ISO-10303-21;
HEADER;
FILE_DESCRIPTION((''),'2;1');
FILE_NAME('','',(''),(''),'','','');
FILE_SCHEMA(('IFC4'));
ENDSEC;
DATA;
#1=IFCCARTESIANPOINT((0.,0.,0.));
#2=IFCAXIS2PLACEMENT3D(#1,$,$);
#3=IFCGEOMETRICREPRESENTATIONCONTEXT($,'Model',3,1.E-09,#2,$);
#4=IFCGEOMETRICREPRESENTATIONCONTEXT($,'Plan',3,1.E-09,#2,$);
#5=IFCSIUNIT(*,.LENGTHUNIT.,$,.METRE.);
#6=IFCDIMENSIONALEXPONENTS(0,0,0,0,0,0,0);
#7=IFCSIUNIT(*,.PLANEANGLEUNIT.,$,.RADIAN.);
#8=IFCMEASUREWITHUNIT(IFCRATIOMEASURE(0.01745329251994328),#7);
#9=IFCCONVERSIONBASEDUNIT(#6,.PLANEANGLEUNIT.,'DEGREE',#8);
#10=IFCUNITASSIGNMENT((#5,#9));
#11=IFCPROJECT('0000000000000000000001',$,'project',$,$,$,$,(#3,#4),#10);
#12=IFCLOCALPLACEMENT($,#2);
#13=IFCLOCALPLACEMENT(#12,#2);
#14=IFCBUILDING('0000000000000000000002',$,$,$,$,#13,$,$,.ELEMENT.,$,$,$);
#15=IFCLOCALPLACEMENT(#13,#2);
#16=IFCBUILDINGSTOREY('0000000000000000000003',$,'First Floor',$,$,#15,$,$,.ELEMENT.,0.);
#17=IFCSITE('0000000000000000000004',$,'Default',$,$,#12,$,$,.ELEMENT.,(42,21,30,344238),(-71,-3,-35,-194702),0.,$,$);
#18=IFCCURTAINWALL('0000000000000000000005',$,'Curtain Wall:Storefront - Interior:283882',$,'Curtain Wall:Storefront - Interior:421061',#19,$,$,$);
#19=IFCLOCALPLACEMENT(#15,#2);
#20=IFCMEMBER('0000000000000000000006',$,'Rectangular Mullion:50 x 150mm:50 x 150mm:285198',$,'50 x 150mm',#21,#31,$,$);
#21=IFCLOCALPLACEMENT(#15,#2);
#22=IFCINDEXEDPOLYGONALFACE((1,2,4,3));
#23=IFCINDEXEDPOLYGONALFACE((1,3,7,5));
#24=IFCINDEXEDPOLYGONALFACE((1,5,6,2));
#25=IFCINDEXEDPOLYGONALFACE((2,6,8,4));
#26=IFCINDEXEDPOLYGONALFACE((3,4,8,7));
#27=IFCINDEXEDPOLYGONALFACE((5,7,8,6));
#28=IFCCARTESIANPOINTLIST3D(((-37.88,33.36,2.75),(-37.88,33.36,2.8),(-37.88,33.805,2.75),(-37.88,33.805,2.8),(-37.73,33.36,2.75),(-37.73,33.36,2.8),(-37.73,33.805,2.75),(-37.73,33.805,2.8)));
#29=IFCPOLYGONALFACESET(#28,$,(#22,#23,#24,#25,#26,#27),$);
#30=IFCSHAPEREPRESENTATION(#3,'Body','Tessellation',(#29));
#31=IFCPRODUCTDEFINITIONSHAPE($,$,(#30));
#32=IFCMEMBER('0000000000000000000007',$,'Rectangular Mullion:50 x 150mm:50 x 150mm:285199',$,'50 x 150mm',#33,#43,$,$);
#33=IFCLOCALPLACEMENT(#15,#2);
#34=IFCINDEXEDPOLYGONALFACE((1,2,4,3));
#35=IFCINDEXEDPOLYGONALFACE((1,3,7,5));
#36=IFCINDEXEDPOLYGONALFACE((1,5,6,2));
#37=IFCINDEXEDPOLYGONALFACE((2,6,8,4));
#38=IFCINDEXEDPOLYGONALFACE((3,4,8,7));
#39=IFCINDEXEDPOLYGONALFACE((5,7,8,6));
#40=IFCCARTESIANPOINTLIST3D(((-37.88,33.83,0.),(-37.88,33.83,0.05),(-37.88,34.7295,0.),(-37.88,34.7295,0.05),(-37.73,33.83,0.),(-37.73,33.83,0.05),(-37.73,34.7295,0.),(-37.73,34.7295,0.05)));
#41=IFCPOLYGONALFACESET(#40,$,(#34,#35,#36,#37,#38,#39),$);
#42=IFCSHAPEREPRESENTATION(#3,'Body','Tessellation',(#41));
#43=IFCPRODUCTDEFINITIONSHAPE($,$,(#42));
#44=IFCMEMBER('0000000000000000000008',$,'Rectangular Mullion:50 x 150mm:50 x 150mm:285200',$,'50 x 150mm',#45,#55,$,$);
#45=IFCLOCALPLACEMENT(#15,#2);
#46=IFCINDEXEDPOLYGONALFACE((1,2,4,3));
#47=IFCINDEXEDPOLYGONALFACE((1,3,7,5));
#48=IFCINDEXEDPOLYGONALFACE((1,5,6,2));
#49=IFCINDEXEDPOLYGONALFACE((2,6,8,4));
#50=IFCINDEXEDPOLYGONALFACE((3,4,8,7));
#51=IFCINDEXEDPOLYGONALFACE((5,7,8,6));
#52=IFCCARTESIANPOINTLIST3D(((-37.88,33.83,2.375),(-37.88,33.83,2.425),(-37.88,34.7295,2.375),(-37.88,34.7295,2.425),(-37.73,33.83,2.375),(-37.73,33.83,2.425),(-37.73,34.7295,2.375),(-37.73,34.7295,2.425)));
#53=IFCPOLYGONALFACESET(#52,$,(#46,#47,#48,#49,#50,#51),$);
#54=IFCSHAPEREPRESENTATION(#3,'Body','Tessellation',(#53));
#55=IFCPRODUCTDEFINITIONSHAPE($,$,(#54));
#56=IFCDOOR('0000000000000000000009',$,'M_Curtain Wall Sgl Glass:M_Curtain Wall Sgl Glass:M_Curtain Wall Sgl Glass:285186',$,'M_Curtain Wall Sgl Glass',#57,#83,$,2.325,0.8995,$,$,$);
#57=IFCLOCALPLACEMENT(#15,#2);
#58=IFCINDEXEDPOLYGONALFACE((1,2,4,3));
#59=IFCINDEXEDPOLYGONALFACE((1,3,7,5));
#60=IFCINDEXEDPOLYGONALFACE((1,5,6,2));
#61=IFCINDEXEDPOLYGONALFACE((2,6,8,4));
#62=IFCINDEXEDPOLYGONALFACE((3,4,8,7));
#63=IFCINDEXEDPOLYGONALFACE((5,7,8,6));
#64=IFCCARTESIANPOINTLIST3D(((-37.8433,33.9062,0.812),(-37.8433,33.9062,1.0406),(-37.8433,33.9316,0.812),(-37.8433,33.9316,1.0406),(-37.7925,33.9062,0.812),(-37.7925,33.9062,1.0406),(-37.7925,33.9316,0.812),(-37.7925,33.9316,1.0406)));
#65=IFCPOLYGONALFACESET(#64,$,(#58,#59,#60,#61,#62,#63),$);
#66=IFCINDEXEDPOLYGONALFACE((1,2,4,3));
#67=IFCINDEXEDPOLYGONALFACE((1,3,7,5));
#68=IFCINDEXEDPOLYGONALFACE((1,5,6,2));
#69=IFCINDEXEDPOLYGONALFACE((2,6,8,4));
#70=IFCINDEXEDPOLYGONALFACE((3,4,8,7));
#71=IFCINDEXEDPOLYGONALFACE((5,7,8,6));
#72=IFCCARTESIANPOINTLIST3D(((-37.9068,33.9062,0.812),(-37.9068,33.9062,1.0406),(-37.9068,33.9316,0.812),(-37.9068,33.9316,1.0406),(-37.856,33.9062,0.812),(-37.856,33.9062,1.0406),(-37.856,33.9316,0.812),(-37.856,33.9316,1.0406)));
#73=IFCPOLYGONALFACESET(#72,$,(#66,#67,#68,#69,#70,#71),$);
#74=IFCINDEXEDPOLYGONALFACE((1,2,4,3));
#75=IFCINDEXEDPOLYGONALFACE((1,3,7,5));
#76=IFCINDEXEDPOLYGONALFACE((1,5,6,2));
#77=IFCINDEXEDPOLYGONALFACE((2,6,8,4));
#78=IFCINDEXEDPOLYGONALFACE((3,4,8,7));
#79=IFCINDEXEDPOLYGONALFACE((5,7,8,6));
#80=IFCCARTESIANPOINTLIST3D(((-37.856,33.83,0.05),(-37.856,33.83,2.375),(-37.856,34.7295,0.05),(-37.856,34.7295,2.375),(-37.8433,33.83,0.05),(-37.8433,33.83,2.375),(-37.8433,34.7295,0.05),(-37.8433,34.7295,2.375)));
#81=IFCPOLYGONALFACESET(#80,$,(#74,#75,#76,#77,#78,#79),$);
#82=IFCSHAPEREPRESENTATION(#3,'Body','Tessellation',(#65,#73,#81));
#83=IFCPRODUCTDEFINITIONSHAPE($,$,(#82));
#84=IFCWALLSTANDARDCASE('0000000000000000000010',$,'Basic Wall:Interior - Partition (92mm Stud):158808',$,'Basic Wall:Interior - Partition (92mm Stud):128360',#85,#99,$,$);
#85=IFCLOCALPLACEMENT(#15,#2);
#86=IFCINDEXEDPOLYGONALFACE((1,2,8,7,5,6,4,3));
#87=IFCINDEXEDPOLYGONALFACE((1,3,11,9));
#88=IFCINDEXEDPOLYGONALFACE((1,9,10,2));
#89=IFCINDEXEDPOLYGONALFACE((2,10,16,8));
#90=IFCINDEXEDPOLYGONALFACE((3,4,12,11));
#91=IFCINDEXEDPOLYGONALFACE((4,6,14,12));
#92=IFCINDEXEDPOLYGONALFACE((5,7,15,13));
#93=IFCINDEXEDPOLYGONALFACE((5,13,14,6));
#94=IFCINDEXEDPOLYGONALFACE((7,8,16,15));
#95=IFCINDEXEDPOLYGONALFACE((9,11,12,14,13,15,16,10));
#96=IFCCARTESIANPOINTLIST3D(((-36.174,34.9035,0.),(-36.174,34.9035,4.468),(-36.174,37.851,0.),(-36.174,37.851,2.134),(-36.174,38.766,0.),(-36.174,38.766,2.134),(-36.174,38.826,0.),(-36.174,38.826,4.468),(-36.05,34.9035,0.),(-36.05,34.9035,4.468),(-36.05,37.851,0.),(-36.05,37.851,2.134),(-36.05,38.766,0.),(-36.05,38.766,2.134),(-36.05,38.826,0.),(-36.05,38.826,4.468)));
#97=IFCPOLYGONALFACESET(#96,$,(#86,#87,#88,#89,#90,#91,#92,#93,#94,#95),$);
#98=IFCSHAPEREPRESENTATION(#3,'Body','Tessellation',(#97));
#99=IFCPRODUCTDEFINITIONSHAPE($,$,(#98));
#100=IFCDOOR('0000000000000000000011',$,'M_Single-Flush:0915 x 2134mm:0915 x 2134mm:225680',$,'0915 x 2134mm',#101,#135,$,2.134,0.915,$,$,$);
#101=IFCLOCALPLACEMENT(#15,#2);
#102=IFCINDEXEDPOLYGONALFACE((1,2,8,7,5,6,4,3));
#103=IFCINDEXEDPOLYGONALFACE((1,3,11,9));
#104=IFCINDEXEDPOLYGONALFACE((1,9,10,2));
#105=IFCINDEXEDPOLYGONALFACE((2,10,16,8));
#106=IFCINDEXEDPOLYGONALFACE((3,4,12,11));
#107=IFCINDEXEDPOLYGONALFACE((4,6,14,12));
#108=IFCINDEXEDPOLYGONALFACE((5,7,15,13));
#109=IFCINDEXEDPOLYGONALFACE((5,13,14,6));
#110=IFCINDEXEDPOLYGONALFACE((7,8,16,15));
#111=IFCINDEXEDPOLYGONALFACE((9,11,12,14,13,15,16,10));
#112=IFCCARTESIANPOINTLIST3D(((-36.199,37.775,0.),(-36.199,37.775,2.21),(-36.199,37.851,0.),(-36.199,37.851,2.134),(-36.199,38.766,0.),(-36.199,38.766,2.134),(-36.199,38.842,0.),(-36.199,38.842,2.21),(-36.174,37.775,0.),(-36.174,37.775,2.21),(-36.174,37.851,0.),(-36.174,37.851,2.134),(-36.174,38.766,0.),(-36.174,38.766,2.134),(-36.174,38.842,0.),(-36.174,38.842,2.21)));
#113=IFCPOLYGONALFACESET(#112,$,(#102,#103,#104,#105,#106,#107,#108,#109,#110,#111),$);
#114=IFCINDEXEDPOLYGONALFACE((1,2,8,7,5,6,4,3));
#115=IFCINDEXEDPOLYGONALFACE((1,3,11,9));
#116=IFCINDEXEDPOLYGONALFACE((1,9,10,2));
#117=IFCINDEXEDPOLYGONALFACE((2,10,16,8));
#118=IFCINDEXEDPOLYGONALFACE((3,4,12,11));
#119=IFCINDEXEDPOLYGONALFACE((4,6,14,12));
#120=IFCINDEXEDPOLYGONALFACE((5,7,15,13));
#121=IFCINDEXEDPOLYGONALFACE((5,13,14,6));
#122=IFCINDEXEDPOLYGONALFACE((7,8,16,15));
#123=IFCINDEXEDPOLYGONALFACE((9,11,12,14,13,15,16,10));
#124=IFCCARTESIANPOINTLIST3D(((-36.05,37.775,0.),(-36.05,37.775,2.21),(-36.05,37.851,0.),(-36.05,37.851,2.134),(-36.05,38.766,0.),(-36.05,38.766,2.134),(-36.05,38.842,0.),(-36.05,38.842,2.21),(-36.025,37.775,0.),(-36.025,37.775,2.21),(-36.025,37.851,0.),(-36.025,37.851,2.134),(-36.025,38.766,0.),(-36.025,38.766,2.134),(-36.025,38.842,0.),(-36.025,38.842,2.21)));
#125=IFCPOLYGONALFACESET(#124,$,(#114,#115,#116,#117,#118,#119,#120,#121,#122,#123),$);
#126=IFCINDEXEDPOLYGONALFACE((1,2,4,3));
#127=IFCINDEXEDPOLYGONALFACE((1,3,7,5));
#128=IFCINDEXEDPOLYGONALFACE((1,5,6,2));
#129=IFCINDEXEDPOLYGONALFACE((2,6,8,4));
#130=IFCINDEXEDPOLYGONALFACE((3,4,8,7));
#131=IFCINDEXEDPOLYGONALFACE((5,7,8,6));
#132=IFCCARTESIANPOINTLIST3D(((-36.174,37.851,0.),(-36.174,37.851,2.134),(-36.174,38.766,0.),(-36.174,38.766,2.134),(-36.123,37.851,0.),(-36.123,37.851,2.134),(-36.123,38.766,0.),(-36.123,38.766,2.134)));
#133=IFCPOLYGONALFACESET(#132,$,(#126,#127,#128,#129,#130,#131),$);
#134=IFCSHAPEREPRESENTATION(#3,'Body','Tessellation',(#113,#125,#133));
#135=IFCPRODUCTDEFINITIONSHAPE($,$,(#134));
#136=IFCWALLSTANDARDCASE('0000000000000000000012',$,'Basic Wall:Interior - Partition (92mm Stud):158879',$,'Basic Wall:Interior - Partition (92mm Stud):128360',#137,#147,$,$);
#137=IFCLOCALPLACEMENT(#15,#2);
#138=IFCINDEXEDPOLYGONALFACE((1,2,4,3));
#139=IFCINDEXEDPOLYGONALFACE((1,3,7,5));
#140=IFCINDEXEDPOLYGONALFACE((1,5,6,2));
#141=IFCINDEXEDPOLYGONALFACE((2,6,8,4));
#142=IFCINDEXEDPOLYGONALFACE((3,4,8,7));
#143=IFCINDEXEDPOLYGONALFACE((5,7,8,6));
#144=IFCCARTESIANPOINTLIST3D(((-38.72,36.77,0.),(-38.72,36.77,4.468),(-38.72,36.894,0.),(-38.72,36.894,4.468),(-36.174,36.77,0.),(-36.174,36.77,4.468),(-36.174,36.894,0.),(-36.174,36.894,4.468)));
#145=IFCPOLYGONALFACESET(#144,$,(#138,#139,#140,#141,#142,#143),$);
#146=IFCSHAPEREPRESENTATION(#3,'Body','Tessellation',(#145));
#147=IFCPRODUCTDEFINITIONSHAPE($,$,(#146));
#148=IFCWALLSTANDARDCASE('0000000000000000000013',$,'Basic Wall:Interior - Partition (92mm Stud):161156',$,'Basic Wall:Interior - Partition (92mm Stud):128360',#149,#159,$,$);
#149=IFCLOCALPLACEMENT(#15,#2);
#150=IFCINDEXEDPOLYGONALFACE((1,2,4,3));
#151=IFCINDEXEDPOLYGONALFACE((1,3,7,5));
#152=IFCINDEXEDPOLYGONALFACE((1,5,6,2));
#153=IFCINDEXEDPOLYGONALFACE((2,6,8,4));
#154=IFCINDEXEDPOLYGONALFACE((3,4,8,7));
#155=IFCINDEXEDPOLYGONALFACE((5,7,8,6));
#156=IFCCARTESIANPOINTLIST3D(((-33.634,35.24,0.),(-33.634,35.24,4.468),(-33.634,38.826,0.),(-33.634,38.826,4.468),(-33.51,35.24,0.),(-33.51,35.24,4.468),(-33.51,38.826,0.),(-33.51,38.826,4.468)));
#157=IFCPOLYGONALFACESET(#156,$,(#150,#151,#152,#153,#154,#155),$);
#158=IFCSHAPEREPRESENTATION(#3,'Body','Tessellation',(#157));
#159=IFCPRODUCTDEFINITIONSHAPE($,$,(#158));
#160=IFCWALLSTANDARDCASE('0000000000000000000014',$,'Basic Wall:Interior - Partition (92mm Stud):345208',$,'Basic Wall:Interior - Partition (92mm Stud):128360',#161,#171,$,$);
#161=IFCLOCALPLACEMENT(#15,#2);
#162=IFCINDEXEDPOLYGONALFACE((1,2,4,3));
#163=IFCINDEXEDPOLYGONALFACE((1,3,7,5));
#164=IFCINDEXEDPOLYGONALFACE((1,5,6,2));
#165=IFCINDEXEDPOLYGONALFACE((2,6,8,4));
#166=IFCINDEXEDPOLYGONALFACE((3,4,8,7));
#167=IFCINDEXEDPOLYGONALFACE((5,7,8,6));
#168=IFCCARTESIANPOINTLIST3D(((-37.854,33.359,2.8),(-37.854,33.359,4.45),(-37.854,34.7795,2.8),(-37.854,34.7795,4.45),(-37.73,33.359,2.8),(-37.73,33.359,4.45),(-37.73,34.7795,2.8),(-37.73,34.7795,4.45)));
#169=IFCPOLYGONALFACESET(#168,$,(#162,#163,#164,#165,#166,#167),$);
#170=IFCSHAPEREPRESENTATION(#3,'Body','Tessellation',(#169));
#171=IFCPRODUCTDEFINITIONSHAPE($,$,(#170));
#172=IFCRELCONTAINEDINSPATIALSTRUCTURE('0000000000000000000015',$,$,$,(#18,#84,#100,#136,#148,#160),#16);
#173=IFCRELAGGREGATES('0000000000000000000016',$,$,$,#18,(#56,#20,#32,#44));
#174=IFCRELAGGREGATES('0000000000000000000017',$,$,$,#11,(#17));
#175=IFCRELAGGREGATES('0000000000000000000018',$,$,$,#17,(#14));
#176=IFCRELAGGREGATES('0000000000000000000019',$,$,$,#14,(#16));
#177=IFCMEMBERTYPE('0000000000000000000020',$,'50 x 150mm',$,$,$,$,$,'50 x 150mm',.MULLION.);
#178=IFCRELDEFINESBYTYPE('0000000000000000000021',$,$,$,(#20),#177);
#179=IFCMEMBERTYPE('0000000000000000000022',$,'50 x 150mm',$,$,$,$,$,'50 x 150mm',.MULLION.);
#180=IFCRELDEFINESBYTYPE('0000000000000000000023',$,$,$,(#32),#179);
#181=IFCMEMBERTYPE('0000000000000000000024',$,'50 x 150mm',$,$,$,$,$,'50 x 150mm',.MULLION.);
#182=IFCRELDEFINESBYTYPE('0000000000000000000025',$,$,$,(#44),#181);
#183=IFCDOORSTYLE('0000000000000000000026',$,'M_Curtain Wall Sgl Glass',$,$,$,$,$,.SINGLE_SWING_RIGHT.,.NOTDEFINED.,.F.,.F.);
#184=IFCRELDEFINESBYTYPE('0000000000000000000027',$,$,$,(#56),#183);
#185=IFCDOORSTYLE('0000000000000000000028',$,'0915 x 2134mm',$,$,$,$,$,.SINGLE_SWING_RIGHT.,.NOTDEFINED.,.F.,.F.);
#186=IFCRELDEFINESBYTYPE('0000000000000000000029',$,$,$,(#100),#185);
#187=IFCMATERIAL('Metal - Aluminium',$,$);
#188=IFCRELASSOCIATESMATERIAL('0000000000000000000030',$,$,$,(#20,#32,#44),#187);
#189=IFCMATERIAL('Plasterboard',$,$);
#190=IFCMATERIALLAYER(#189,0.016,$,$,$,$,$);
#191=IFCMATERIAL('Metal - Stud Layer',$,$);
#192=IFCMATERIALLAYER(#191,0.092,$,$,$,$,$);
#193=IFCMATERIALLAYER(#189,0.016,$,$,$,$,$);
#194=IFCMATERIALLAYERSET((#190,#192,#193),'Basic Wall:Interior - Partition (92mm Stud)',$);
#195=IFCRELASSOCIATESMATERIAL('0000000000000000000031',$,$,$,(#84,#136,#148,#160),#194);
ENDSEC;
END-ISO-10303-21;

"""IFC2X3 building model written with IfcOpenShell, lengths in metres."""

from ifc_helpers import new_model, entity, si_unit, converted_unit, frame, frame_2d, origin, origin_2d_with_axis, place, context, project, spatial, polyline, rectangle, outline, extrude, source, transform, mapped, material, layer, layer_set, layer_usage, type_object, type_shapes, element, fill, aggregate, save


model = new_model("IFC2X3")

# Units and contexts
model_context = context("Model", 3, precision=1e-09, world=origin())
plan_context = context("Plan", 3, precision=1e-09, world=origin())
ifc_project = project(units=[si_unit("LENGTHUNIT", "METRE"), converted_unit("PLANEANGLEUNIT", "DEGREE", entity("IfcRatioMeasure", 0.01745329251994328), si_unit("PLANEANGLEUNIT", "RADIAN"), dimensions=[0, 0, 0, 0, 0, 0, 0])], contexts=[model_context, plan_context])

# Site, building, storey
site_placement = place(None, origin())
site = spatial("IfcSite", under=ifc_project, at=site_placement, Name="Default", CompositionType="ELEMENT", RefLatitude=(42, 21, 30, 344238), RefLongitude=(-71, -3, -35, -194702), RefElevation=0.0)
building_placement = place(site_placement, origin())
building = spatial("IfcBuilding", under=site, at=building_placement, CompositionType="ELEMENT")
storey_placement = place(building_placement, origin())
storey = spatial("IfcBuildingStorey", under=building, at=storey_placement, Name="First Floor", CompositionType="ELEMENT", Elevation=0.0)

# Shared definitions
ifc_material_1 = material(Name="Metal - Aluminium")

# Curtain wall
curtain_wall_1_placement = place(storey_placement, origin())
curtain_wall_1 = element("IfcCurtainWall", 1, at=curtain_wall_1_placement, inside=storey, Name="Curtain Wall:Storefront - Interior:283882", ObjectType="Curtain Wall:Storefront - Interior:421061")

# Members
member_type_1 = type_object("IfcMemberType", Name="50 x 150mm", ElementType="50 x 150mm", PredefinedType="MULLION")
shared_shape_1 = source(origin(), model_context, "Body", "SweptSolid", [
    extrude(rectangle(XDim=0.05, YDim=0.15, at=origin_2d_with_axis()), frame((-0.025, 0.0, -0.445), z_axis=(0.0, 0.0, 1.0), x_axis=(-1.0, 0.0, 0.0)), (0.0, 0.0, 1.0), 0.445),
])
type_shapes(member_type_1, [shared_shape_1])
member_1_placement = place(storey_placement, frame((-37.805, 33.805, 2.8), z_axis=(0.0, 1.0, 0.0), x_axis=(0.0, 0.0, 1.0)))
member_1 = element("IfcMember", 2, at=member_1_placement, type_object=member_type_1, material=ifc_material_1, Name="Rectangular Mullion:50 x 150mm:50 x 150mm:285198", ObjectType="50 x 150mm", context=model_context, shape_type="MappedRepresentation", body=[
    mapped(shared_shape_1, transform((0.0, 0.0, 0.0), scale=1.0)),
])
member_type_2 = type_object("IfcMemberType", Name="50 x 150mm", ElementType="50 x 150mm", PredefinedType="MULLION")
shared_shape_2 = source(origin(), model_context, "Body", "SweptSolid", [
    extrude(rectangle(XDim=0.05, YDim=0.15, at=origin_2d_with_axis()), frame((-0.025, 0.0, -0.8995), z_axis=(0.0, 0.0, 1.0), x_axis=(-1.0, 0.0, 0.0)), (0.0, 0.0, 1.0), 0.8995),
])
type_shapes(member_type_2, [shared_shape_2])
member_2_placement = place(storey_placement, frame((-37.805, 33.83, 0.0), z_axis=(0.0, -1.0, 0.0), x_axis=(0.0, 0.0, -1.0)))
member_2 = element("IfcMember", 3, at=member_2_placement, type_object=member_type_2, material=ifc_material_1, Name="Rectangular Mullion:50 x 150mm:50 x 150mm:285199", ObjectType="50 x 150mm", context=model_context, shape_type="MappedRepresentation", body=[
    mapped(shared_shape_2, transform((0.0, 0.0, 0.0), scale=1.0)),
])
member_type_3 = type_object("IfcMemberType", Name="50 x 150mm", ElementType="50 x 150mm", PredefinedType="MULLION")
shared_shape_3 = source(origin(), model_context, "Body", "SweptSolid", [
    extrude(rectangle(XDim=0.05, YDim=0.15, at=origin_2d_with_axis()), frame((0.0, 0.0, -0.8995), z_axis=(0.0, 0.0, 1.0), x_axis=(-1.0, 0.0, 0.0)), (0.0, 0.0, 1.0), 0.8995),
])
type_shapes(member_type_3, [shared_shape_3])
member_3_placement = place(storey_placement, frame((-37.805, 34.7295, 2.4), z_axis=(0.0, 1.0, 0.0), x_axis=(0.0, 0.0, 1.0)))
member_3 = element("IfcMember", 4, at=member_3_placement, type_object=member_type_3, material=ifc_material_1, Name="Rectangular Mullion:50 x 150mm:50 x 150mm:285200", ObjectType="50 x 150mm", context=model_context, shape_type="MappedRepresentation", body=[
    mapped(shared_shape_3, transform((0.0, 0.0, 0.0), scale=1.0)),
])

# Door
door_style_1 = type_object("IfcDoorStyle", Name="M_Curtain Wall Sgl Glass", ConstructionType="NOTDEFINED", OperationType="SINGLE_SWING_RIGHT", ParameterTakesPrecedence=False, Sizeable=False)
shared_shape_4 = source(origin(), model_context, "Body", "SweptSolid", [
    extrude(rectangle(XDim=0.0508, YDim=0.0254, at=origin_2d_with_axis()), frame((-0.3609, 0.0129, 0.762), z_axis=(0.0, 0.0, 1.0), x_axis=(0.0, 1.0, 0.0)), (0.0, 0.0, 1.0), 0.2286),
    extrude(rectangle(XDim=0.0508, YDim=0.0254, at=origin_2d_with_axis()), frame((-0.3609, 0.0764, 0.762), z_axis=(0.0, 0.0, 1.0), x_axis=(0.0, -1.0, 0.0)), (0.0, 0.0, 1.0), 0.2286),
    extrude(rectangle(XDim=0.8995, YDim=0.0127, at=origin_2d_with_axis()), frame((0.0, 0.0447, 0.0), z_axis=(0.0, 0.0, 1.0), x_axis=(-1.0, 0.0, 0.0)), (0.0, 0.0, 1.0), 2.325),
])
type_shapes(door_style_1, [shared_shape_4])
door_1_placement = place(storey_placement, frame((-37.805, 34.2798, 0.05), z_axis=(0.0, 0.0, 1.0), x_axis=(0.0, 1.0, 0.0)))
door_1 = element("IfcDoor", 5, at=door_1_placement, type_object=door_style_1, Name="M_Curtain Wall Sgl Glass:M_Curtain Wall Sgl Glass:M_Curtain Wall Sgl Glass:285186", ObjectType="M_Curtain Wall Sgl Glass", OverallHeight=2.325, OverallWidth=0.8995, context=model_context, shape_type="MappedRepresentation", body=[
    mapped(shared_shape_4, transform((0.0, 0.0, 0.0), scale=1.0)),
])
aggregate(curtain_wall_1, [door_1, member_1, member_2, member_3])

# Wall, opening, door
ifc_material_2 = material(Name="Plasterboard")
ifc_layer_1 = layer(ifc_material_2, 0.016)
ifc_material_3 = material(Name="Metal - Stud Layer")
ifc_layer_2 = layer(ifc_material_3, 0.092)
ifc_layer_3 = layer(ifc_material_2, 0.016)
ifc_layer_set_1 = layer_set([ifc_layer_1, ifc_layer_2, ifc_layer_3], Name="Basic Wall:Interior - Partition (92mm Stud)")
ifc_layer_usage_1 = layer_usage(ifc_layer_set_1, "AXIS2", "NEGATIVE", 0.062)
wall_1_placement = place(storey_placement, frame((-36.112, 38.826, 0.0), z_axis=(0.0, 0.0, 1.0), x_axis=(0.0, -1.0, 0.0)))
wall_1 = element("IfcWallStandardCase", 6, at=wall_1_placement, inside=storey, material=ifc_layer_usage_1, Name="Basic Wall:Interior - Partition (92mm Stud):158808", ObjectType="Basic Wall:Interior - Partition (92mm Stud):128360", context=model_context, shape_type="SweptSolid", body=[
    extrude(rectangle(XDim=3.9225, YDim=0.124, at=frame_2d((1.9612, 0.0), x_axis=(-1.0, 0.0))), origin(), (0.0, 0.0, 1.0), 4.468),
])
opening_placement = place(wall_1_placement, frame((0.975, 0.062, 0.0)))
opening = element("IfcOpeningElement", 7, at=opening_placement, cuts=wall_1, ObjectType="Opening", context=model_context, shape_type="SweptSolid", body=[
    extrude(rectangle(XDim=0.915, YDim=2.134, at=frame_2d((1.067, 0.4575), x_axis=(0.0, 1.0))), frame((0.0, 0.0, 0.0), z_axis=(0.0, -1.0, 0.0), x_axis=(0.0, 0.0, 1.0)), (0.0, 0.0, 1.0), 0.124),
])
door_style_2 = type_object("IfcDoorStyle", Name="0915 x 2134mm", ConstructionType="NOTDEFINED", OperationType="SINGLE_SWING_RIGHT", ParameterTakesPrecedence=False, Sizeable=False)
shared_shape_5 = source(origin(), model_context, "Body", "SweptSolid", [
    extrude(outline(polyline([(-0.5335, -1.124), (0.5335, -1.124), (0.5335, 1.086), (0.4575, 1.086), (0.4575, -1.048), (-0.4575, -1.048), (-0.4575, 1.086), (-0.5335, 1.086), (-0.5335, -1.124)])), frame((0.4575, 0.124, 1.086), z_axis=(0.0, 1.0, 0.0), x_axis=(1.0, 0.0, 0.0)), (0.0, 0.0, 1.0), 0.025),
    extrude(outline(polyline([(-1.124, -0.5335), (1.086, -0.5335), (1.086, -0.4575), (-1.048, -0.4575), (-1.048, 0.4575), (1.086, 0.4575), (1.086, 0.5335), (-1.124, 0.5335), (-1.124, -0.5335)])), frame((0.4575, -0.025, 1.086), z_axis=(0.0, 1.0, 0.0), x_axis=(0.0, 0.0, -1.0)), (0.0, 0.0, 1.0), 0.025),
    extrude(rectangle(XDim=0.051, YDim=0.915, at=origin_2d_with_axis()), frame((0.4575, 0.0985, 0.0), z_axis=(0.0, 0.0, 1.0), x_axis=(0.0, 1.0, 0.0)), (0.0, 0.0, 1.0), 2.134),
])
type_shapes(door_style_2, [shared_shape_5])
door_2_placement = place(opening_placement, frame((0.0, 0.0, 0.0), z_axis=(0.0, 0.0, 1.0), x_axis=(-1.0, 0.0, 0.0)))
door_2 = element("IfcDoor", 8, at=door_2_placement, inside=storey, type_object=door_style_2, Name="M_Single-Flush:0915 x 2134mm:0915 x 2134mm:225680", ObjectType="0915 x 2134mm", OverallHeight=2.134, OverallWidth=0.915, context=model_context, shape_type="MappedRepresentation", body=[
    mapped(shared_shape_5, transform((0.0, 0.0, 0.0), scale=1.0)),
])
fill(opening, door_2)

# Walls
ifc_layer_usage_2 = layer_usage(ifc_layer_set_1, "AXIS2", "NEGATIVE", 0.062)
wall_2_placement = place(storey_placement, frame((-36.174, 36.832, 0.0), z_axis=(0.0, 0.0, 1.0), x_axis=(-1.0, 0.0, 0.0)))
element("IfcWallStandardCase", 9, at=wall_2_placement, inside=storey, material=ifc_layer_usage_2, Name="Basic Wall:Interior - Partition (92mm Stud):158879", ObjectType="Basic Wall:Interior - Partition (92mm Stud):128360", context=model_context, shape_type="SweptSolid", body=[
    extrude(rectangle(XDim=2.546, YDim=0.124, at=frame_2d((1.273, 0.0), x_axis=(-1.0, 0.0))), origin(), (0.0, 0.0, 1.0), 4.468),
])
ifc_layer_usage_3 = layer_usage(ifc_layer_set_1, "AXIS2", "NEGATIVE", 0.062)
wall_3_placement = place(storey_placement, frame((-33.572, 38.826, 0.0), z_axis=(0.0, 0.0, 1.0), x_axis=(0.0, -1.0, 0.0)))
element("IfcWallStandardCase", 10, at=wall_3_placement, inside=storey, material=ifc_layer_usage_3, Name="Basic Wall:Interior - Partition (92mm Stud):161156", ObjectType="Basic Wall:Interior - Partition (92mm Stud):128360", context=model_context, shape_type="SweptSolid", body=[
    extrude(rectangle(XDim=3.586, YDim=0.124, at=frame_2d((1.793, 0.0), x_axis=(-1.0, 0.0))), origin(), (0.0, 0.0, 1.0), 4.468),
])
ifc_layer_usage_4 = layer_usage(ifc_layer_set_1, "AXIS2", "NEGATIVE", 0.062)
wall_4_placement = place(storey_placement, frame((-37.792, 34.7795, 2.8), z_axis=(0.0, 0.0, 1.0), x_axis=(0.0, -1.0, 0.0)))
element("IfcWallStandardCase", 11, at=wall_4_placement, inside=storey, material=ifc_layer_usage_4, Name="Basic Wall:Interior - Partition (92mm Stud):345208", ObjectType="Basic Wall:Interior - Partition (92mm Stud):128360", context=model_context, shape_type="SweptSolid", body=[
    extrude(rectangle(XDim=1.4205, YDim=0.124, at=frame_2d((0.7103, 0.0), x_axis=(-1.0, 0.0))), origin(), (0.0, 0.0, 1.0), 1.65),
])

save(model, "model.ifc")
